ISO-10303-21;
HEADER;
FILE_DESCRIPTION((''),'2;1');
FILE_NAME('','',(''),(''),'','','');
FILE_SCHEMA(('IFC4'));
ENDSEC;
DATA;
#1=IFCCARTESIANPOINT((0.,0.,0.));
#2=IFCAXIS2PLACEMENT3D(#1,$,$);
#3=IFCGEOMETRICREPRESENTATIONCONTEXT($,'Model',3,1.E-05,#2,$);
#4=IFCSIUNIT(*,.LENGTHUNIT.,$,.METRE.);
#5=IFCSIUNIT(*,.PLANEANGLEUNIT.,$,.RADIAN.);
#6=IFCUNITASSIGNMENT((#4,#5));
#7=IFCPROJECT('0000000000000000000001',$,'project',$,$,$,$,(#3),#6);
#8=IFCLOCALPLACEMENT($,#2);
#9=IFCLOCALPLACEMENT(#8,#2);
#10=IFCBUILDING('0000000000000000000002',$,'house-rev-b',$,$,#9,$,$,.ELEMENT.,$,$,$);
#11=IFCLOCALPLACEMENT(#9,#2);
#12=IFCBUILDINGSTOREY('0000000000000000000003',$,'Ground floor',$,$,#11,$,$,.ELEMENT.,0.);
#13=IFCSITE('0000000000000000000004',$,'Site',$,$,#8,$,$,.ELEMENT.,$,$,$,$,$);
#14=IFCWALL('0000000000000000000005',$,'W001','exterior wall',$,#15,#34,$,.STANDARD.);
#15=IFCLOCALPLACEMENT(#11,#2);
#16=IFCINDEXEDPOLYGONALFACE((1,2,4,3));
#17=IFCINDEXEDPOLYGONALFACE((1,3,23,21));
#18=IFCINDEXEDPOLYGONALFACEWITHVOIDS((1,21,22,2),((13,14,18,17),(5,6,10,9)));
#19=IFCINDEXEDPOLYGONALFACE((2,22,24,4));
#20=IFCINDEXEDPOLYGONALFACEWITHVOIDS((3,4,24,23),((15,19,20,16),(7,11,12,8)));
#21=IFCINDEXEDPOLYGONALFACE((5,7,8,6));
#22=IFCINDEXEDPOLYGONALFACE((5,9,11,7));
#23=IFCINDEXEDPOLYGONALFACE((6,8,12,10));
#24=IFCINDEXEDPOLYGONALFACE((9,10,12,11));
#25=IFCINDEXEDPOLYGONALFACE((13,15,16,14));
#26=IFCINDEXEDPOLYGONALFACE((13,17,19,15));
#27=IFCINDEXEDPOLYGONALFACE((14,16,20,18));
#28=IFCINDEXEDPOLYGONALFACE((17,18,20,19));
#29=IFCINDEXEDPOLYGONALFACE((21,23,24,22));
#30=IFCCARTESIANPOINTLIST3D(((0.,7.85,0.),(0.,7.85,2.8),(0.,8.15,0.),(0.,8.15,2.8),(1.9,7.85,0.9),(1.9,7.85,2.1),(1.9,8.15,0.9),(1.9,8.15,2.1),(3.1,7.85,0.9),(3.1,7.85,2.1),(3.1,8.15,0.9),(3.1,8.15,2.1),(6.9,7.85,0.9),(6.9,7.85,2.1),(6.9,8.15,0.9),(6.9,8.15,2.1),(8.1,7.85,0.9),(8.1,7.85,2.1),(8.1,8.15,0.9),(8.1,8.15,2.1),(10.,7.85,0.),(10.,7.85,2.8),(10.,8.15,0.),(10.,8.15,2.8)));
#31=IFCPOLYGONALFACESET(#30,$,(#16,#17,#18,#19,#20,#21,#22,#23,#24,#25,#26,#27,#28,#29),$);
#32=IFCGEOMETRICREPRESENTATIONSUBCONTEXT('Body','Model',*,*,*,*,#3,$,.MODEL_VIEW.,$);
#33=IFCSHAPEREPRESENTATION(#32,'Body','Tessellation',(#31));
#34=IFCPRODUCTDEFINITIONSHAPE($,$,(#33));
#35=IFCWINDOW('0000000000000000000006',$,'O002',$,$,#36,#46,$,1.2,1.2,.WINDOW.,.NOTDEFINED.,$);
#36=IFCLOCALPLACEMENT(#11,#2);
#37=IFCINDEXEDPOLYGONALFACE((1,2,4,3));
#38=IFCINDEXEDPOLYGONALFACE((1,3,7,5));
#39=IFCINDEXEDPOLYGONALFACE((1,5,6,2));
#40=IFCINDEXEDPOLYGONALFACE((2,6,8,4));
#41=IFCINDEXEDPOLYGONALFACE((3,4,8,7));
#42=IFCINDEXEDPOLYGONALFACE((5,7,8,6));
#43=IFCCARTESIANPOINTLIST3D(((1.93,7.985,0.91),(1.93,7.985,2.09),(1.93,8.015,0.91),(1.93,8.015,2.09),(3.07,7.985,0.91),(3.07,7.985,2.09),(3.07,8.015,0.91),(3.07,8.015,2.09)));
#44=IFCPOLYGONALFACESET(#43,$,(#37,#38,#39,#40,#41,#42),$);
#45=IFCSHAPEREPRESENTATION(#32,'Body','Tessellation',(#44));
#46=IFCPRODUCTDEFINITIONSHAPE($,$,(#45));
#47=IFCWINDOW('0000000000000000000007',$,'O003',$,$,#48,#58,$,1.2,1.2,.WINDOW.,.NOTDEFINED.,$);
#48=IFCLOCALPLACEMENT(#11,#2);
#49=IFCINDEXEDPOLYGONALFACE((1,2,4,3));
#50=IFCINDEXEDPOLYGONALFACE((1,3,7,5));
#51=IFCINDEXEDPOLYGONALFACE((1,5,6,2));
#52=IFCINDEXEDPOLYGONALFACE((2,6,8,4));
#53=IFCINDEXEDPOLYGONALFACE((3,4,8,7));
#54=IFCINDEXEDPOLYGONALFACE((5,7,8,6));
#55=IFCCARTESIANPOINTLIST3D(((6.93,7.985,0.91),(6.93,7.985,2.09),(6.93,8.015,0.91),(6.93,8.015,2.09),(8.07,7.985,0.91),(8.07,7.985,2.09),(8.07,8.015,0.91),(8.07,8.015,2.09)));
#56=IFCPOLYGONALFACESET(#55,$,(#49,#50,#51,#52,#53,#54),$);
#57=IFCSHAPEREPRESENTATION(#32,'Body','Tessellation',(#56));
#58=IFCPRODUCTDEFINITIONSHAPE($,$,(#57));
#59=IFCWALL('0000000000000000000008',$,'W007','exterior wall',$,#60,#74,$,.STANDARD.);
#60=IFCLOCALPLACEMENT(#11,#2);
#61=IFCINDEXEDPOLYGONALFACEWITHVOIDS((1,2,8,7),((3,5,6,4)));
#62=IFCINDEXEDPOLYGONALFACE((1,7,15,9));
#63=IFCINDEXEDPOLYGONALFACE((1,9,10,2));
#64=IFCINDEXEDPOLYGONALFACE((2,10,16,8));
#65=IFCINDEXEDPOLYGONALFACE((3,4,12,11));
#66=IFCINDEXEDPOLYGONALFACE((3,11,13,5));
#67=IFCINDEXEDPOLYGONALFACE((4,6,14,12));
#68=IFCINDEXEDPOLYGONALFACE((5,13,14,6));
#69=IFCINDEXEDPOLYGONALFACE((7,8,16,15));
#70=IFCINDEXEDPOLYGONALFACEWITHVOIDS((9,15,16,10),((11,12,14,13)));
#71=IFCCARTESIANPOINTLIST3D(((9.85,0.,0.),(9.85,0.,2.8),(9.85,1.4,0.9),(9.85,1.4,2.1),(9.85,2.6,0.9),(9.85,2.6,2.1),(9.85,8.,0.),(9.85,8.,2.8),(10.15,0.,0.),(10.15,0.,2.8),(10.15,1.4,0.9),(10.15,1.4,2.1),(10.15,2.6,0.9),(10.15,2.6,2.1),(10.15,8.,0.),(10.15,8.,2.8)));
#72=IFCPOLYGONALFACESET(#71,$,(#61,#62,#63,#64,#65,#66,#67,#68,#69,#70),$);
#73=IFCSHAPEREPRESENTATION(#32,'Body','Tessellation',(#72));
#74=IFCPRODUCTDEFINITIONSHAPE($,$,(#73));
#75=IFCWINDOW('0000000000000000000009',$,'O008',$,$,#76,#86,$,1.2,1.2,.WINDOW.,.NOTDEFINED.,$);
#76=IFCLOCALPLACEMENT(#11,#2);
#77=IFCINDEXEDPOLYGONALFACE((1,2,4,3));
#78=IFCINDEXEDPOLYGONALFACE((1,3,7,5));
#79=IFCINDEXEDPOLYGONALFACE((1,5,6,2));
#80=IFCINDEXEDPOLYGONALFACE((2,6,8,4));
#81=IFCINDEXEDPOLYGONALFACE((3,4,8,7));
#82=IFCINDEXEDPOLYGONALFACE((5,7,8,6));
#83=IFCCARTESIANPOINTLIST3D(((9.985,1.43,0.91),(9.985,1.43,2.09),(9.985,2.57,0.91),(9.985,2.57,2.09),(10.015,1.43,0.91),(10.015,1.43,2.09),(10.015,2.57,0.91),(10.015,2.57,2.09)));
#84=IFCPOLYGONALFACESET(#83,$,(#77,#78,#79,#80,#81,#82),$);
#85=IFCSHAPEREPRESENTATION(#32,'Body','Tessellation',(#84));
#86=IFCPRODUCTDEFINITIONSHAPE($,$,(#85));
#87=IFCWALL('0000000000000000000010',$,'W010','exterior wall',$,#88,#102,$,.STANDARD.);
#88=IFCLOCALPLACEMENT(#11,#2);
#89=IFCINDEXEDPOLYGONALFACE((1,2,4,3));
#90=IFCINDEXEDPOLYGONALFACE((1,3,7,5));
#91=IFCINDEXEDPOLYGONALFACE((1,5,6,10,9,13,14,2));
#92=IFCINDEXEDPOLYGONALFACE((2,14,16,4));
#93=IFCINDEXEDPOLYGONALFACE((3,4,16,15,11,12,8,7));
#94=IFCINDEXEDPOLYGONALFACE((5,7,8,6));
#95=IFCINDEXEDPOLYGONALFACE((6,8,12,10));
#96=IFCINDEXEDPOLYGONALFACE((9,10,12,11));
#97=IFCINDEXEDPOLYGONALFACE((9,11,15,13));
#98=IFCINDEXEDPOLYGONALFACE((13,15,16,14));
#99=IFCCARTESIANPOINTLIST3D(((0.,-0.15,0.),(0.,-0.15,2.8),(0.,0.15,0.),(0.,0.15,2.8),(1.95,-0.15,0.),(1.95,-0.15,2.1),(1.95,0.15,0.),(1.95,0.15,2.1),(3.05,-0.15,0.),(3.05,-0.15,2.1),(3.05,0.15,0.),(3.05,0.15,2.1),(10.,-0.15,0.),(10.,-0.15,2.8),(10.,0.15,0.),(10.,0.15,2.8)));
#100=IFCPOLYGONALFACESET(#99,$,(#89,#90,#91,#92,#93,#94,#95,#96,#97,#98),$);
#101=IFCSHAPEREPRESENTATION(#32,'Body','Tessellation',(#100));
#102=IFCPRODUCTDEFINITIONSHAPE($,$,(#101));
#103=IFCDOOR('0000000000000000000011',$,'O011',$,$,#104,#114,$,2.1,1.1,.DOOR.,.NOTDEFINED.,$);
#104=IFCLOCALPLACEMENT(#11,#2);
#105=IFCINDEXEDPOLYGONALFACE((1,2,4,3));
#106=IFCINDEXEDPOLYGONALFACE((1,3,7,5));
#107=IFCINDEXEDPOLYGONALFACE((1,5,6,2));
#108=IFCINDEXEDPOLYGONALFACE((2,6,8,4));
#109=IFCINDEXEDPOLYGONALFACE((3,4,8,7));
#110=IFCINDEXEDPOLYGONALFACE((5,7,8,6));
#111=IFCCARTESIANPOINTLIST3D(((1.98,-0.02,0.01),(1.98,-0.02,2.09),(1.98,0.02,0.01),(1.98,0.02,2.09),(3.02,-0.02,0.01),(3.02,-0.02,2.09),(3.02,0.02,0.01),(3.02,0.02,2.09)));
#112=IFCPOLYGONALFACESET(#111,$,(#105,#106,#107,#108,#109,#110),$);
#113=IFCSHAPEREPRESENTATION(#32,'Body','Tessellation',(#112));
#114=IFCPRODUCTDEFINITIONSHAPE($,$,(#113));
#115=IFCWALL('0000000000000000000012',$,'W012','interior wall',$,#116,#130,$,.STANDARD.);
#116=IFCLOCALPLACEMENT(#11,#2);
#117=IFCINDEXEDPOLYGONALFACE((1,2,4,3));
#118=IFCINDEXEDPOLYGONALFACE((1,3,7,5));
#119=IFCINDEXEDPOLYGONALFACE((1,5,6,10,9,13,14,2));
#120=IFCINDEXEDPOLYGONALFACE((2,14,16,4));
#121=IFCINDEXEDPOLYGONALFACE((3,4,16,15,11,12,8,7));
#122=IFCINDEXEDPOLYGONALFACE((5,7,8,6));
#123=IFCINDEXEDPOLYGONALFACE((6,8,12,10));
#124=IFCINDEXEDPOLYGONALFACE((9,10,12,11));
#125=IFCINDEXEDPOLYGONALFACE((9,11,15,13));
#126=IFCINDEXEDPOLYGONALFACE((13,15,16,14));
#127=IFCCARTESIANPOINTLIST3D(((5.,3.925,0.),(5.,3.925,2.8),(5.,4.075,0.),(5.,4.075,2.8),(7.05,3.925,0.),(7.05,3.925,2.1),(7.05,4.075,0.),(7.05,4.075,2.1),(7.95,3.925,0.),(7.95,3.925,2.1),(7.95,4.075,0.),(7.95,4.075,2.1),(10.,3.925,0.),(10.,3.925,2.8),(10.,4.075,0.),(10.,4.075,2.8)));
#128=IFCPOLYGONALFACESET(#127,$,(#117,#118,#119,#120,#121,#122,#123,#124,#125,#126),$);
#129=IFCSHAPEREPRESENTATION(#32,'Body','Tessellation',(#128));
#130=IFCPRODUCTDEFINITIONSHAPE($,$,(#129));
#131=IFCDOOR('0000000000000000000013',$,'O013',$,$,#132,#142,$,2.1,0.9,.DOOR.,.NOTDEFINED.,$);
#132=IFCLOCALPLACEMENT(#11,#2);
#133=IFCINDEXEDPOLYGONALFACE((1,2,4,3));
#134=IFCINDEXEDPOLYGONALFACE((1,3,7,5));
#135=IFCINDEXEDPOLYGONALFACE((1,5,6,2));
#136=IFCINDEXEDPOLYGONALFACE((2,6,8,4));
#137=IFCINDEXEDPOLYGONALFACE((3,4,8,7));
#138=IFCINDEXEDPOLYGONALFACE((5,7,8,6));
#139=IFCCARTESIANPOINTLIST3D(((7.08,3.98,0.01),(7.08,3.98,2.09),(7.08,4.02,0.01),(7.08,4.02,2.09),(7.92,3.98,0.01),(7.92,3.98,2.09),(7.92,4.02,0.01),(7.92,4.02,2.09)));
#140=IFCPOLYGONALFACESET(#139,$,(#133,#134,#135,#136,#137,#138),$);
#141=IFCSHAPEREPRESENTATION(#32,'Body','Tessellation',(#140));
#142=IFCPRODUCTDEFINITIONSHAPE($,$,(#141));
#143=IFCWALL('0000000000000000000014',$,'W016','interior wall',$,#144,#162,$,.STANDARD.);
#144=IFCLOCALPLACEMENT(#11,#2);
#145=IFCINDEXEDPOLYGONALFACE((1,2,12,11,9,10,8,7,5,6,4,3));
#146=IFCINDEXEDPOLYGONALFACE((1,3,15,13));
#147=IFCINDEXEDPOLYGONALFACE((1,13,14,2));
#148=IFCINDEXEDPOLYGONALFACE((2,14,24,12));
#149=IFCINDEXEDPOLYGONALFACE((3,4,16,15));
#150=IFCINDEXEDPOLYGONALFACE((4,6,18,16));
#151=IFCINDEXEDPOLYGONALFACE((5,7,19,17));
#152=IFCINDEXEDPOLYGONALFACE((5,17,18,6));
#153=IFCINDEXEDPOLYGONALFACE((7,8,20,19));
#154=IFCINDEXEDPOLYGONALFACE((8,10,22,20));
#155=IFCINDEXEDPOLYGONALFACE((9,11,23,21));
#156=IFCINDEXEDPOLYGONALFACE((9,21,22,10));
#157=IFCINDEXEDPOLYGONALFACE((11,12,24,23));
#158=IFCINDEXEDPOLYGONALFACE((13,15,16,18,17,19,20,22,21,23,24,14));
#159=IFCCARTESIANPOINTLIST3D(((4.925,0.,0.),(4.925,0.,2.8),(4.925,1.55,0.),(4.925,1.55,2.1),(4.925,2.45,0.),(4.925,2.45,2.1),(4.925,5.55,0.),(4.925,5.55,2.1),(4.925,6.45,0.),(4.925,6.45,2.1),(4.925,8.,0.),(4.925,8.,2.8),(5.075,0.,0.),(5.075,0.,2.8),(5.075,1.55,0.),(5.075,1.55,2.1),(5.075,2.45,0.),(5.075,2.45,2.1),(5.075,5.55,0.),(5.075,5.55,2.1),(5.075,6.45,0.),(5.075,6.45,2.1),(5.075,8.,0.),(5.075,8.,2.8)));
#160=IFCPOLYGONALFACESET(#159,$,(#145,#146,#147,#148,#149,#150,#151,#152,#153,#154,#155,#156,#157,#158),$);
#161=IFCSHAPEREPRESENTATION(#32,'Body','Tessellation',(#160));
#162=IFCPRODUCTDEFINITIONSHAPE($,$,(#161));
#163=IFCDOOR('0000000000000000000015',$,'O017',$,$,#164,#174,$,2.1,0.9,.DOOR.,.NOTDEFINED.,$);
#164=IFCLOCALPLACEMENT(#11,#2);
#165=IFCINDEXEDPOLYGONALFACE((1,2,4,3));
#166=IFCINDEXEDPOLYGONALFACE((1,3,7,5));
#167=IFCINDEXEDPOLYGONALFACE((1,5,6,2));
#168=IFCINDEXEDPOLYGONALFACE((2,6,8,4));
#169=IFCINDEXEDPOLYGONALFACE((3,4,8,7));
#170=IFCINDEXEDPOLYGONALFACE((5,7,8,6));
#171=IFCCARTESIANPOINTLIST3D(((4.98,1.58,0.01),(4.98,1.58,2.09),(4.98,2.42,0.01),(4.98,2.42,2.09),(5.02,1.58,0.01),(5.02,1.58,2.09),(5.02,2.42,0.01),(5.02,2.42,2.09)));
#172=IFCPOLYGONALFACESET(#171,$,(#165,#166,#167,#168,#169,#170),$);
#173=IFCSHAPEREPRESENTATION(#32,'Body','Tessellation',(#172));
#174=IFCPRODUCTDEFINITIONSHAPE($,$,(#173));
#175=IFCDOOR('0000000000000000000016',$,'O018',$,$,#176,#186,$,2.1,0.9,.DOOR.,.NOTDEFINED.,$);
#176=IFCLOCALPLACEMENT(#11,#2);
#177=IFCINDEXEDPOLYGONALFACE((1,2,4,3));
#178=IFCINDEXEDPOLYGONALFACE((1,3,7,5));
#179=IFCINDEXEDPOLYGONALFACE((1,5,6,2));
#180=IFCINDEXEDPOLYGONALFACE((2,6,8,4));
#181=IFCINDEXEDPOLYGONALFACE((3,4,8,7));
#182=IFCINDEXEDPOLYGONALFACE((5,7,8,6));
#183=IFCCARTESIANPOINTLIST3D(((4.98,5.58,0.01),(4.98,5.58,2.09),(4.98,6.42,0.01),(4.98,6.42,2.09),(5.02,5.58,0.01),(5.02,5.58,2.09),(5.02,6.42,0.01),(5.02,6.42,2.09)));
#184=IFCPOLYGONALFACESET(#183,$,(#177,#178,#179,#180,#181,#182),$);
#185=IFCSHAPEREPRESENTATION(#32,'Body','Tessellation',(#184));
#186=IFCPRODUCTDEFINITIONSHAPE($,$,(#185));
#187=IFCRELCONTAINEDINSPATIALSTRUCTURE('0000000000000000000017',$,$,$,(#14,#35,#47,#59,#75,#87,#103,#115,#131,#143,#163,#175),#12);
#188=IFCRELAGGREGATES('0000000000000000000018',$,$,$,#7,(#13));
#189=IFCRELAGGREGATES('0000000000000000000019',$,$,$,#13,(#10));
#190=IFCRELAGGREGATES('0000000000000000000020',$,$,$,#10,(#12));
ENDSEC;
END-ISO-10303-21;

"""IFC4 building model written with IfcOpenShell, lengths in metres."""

from ifc_helpers import new_model, si_unit, frame, origin, origin_2d, place, context, subcontext, project, spatial, rectangle, extrude, element, fill, save


model = new_model("IFC4")

# Units and contexts
model_context = context("Model", 3, precision=1e-05, world=origin())
body_context = subcontext(model_context, "Body", "Model", "MODEL_VIEW")
ifc_project = project(units=[si_unit("LENGTHUNIT", "METRE"), si_unit("PLANEANGLEUNIT", "RADIAN")], contexts=[model_context])

# Site, building, storey
site_placement = place(None, origin())
site = spatial("IfcSite", under=ifc_project, at=site_placement, Name="Site", CompositionType="ELEMENT")
building_placement = place(site_placement, origin())
building = spatial("IfcBuilding", under=site, at=building_placement, Name="house-rev-b", CompositionType="ELEMENT")
storey_placement = place(building_placement, origin())
storey = spatial("IfcBuildingStorey", under=building, at=storey_placement, Name="Ground floor", CompositionType="ELEMENT", Elevation=0.0)

# Wall, openings, windows
wall_1_placement = place(storey_placement, frame((5.0, 8.0, 0.0), z_axis=(0.0, 0.0, 1.0), x_axis=(1.0, 0.0, 0.0)))
wall_1 = element("IfcWall", 1, at=wall_1_placement, inside=storey, Name="W001", Description="exterior wall", PredefinedType="STANDARD", context=body_context, shape_type="SweptSolid", body=[
    extrude(rectangle(XDim=10.0, YDim=0.3, at=origin_2d()), origin(), (0.0, 0.0, 1.0), 2.8),
])
opening_1_placement = place(wall_1_placement, frame((-2.5, 0.0, 0.9)))
opening_1 = element("IfcOpeningElement", 2, at=opening_1_placement, cuts=wall_1, PredefinedType="OPENING", context=body_context, shape_type="SweptSolid", body=[
    extrude(rectangle(XDim=1.2, YDim=0.36, at=origin_2d()), origin(), (0.0, 0.0, 1.0), 1.2),
])
opening_2_placement = place(wall_1_placement, frame((2.5, 0.0, 0.9)))
opening_2 = element("IfcOpeningElement", 3, at=opening_2_placement, cuts=wall_1, PredefinedType="OPENING", context=body_context, shape_type="SweptSolid", body=[
    extrude(rectangle(XDim=1.2, YDim=0.36, at=origin_2d()), origin(), (0.0, 0.0, 1.0), 1.2),
])
window_1_placement = place(wall_1_placement, frame((-2.5, 0.0, 0.9)))
window_1 = element("IfcWindow", 4, at=window_1_placement, inside=storey, Name="O002", OverallHeight=1.2, OverallWidth=1.2, PartitioningType="NOTDEFINED", PredefinedType="WINDOW", context=body_context, shape_type="SweptSolid", body=[
    extrude(rectangle(XDim=1.14, YDim=0.03, at=origin_2d()), frame((0.0, 0.0, 0.01)), (0.0, 0.0, 1.0), 1.18),
])
fill(opening_1, window_1)
window_2_placement = place(wall_1_placement, frame((2.5, 0.0, 0.9)))
window_2 = element("IfcWindow", 5, at=window_2_placement, inside=storey, Name="O003", OverallHeight=1.2, OverallWidth=1.2, PartitioningType="NOTDEFINED", PredefinedType="WINDOW", context=body_context, shape_type="SweptSolid", body=[
    extrude(rectangle(XDim=1.14, YDim=0.03, at=origin_2d()), frame((0.0, 0.0, 0.01)), (0.0, 0.0, 1.0), 1.18),
])
fill(opening_2, window_2)

# Wall, opening, window
wall_2_placement = place(storey_placement, frame((10.0, 4.0, 0.0), z_axis=(0.0, 0.0, 1.0), x_axis=(0.0, 1.0, 0.0)))
wall_2 = element("IfcWall", 6, at=wall_2_placement, inside=storey, Name="W007", Description="exterior wall", PredefinedType="STANDARD", context=body_context, shape_type="SweptSolid", body=[
    extrude(rectangle(XDim=8.0, YDim=0.3, at=origin_2d()), origin(), (0.0, 0.0, 1.0), 2.8),
])
opening_3_placement = place(wall_2_placement, frame((-2.0, 0.0, 0.9)))
opening_3 = element("IfcOpeningElement", 7, at=opening_3_placement, cuts=wall_2, PredefinedType="OPENING", context=body_context, shape_type="SweptSolid", body=[
    extrude(rectangle(XDim=1.2, YDim=0.36, at=origin_2d()), origin(), (0.0, 0.0, 1.0), 1.2),
])
window_3_placement = place(wall_2_placement, frame((-2.0, 0.0, 0.9)))
window_3 = element("IfcWindow", 8, at=window_3_placement, inside=storey, Name="O008", OverallHeight=1.2, OverallWidth=1.2, PartitioningType="NOTDEFINED", PredefinedType="WINDOW", context=body_context, shape_type="SweptSolid", body=[
    extrude(rectangle(XDim=1.14, YDim=0.03, at=origin_2d()), frame((0.0, 0.0, 0.01)), (0.0, 0.0, 1.0), 1.18),
])
fill(opening_3, window_3)

# Walls, openings, doors
wall_3_placement = place(storey_placement, frame((5.0, 0.0, 0.0), z_axis=(0.0, 0.0, 1.0), x_axis=(1.0, 0.0, 0.0)))
wall_3 = element("IfcWall", 9, at=wall_3_placement, inside=storey, Name="W010", Description="exterior wall", PredefinedType="STANDARD", context=body_context, shape_type="SweptSolid", body=[
    extrude(rectangle(XDim=10.0, YDim=0.3, at=origin_2d()), origin(), (0.0, 0.0, 1.0), 2.8),
])
opening_4_placement = place(wall_3_placement, frame((-2.5, 0.0, 0.0)))
opening_4 = element("IfcOpeningElement", 10, at=opening_4_placement, cuts=wall_3, PredefinedType="OPENING", context=body_context, shape_type="SweptSolid", body=[
    extrude(rectangle(XDim=1.1, YDim=0.36, at=origin_2d()), origin(), (0.0, 0.0, 1.0), 2.1),
])
door_1_placement = place(wall_3_placement, frame((-2.5, 0.0, 0.0)))
door_1 = element("IfcDoor", 11, at=door_1_placement, inside=storey, Name="O011", OperationType="NOTDEFINED", OverallHeight=2.1, OverallWidth=1.1, PredefinedType="DOOR", context=body_context, shape_type="SweptSolid", body=[
    extrude(rectangle(XDim=1.04, YDim=0.04, at=origin_2d()), frame((0.0, 0.0, 0.01)), (0.0, 0.0, 1.0), 2.08),
])
fill(opening_4, door_1)
wall_4_placement = place(storey_placement, frame((7.5, 4.0, 0.0), z_axis=(0.0, 0.0, 1.0), x_axis=(1.0, 0.0, 0.0)))
wall_4 = element("IfcWall", 12, at=wall_4_placement, inside=storey, Name="W012", Description="interior wall", PredefinedType="STANDARD", context=body_context, shape_type="SweptSolid", body=[
    extrude(rectangle(XDim=5.0, YDim=0.15, at=origin_2d()), origin(), (0.0, 0.0, 1.0), 2.8),
])
opening_5_placement = place(wall_4_placement, origin())
opening_5 = element("IfcOpeningElement", 13, at=opening_5_placement, cuts=wall_4, PredefinedType="OPENING", context=body_context, shape_type="SweptSolid", body=[
    extrude(rectangle(XDim=0.9, YDim=0.18, at=origin_2d()), origin(), (0.0, 0.0, 1.0), 2.1),
])
door_2_placement = place(wall_4_placement, origin())
door_2 = element("IfcDoor", 14, at=door_2_placement, inside=storey, Name="O013", OperationType="NOTDEFINED", OverallHeight=2.1, OverallWidth=0.9, PredefinedType="DOOR", context=body_context, shape_type="SweptSolid", body=[
    extrude(rectangle(XDim=0.84, YDim=0.04, at=origin_2d()), frame((0.0, 0.0, 0.01)), (0.0, 0.0, 1.0), 2.08),
])
fill(opening_5, door_2)

# Wall, openings, doors
wall_5_placement = place(storey_placement, frame((5.0, 4.0, 0.0), z_axis=(0.0, 0.0, 1.0), x_axis=(0.0, 1.0, 0.0)))
wall_5 = element("IfcWall", 15, at=wall_5_placement, inside=storey, Name="W016", Description="interior wall", PredefinedType="STANDARD", context=body_context, shape_type="SweptSolid", body=[
    extrude(rectangle(XDim=8.0, YDim=0.15, at=origin_2d()), origin(), (0.0, 0.0, 1.0), 2.8),
])
opening_6_placement = place(wall_5_placement, frame((-2.0, 0.0, 0.0)))
opening_6 = element("IfcOpeningElement", 16, at=opening_6_placement, cuts=wall_5, PredefinedType="OPENING", context=body_context, shape_type="SweptSolid", body=[
    extrude(rectangle(XDim=0.9, YDim=0.18, at=origin_2d()), origin(), (0.0, 0.0, 1.0), 2.1),
])
opening_7_placement = place(wall_5_placement, frame((2.0, 0.0, 0.0)))
opening_7 = element("IfcOpeningElement", 17, at=opening_7_placement, cuts=wall_5, PredefinedType="OPENING", context=body_context, shape_type="SweptSolid", body=[
    extrude(rectangle(XDim=0.9, YDim=0.18, at=origin_2d()), origin(), (0.0, 0.0, 1.0), 2.1),
])
door_3_placement = place(wall_5_placement, frame((-2.0, 0.0, 0.0)))
door_3 = element("IfcDoor", 18, at=door_3_placement, inside=storey, Name="O017", OperationType="NOTDEFINED", OverallHeight=2.1, OverallWidth=0.9, PredefinedType="DOOR", context=body_context, shape_type="SweptSolid", body=[
    extrude(rectangle(XDim=0.84, YDim=0.04, at=origin_2d()), frame((0.0, 0.0, 0.01)), (0.0, 0.0, 1.0), 2.08),
])
fill(opening_6, door_3)
door_4_placement = place(wall_5_placement, frame((2.0, 0.0, 0.0)))
door_4 = element("IfcDoor", 19, at=door_4_placement, inside=storey, Name="O018", OperationType="NOTDEFINED", OverallHeight=2.1, OverallWidth=0.9, PredefinedType="DOOR", context=body_context, shape_type="SweptSolid", body=[
    extrude(rectangle(XDim=0.84, YDim=0.04, at=origin_2d()), frame((0.0, 0.0, 0.01)), (0.0, 0.0, 1.0), 2.08),
])
fill(opening_7, door_4)

save(model, "model.ifc")
